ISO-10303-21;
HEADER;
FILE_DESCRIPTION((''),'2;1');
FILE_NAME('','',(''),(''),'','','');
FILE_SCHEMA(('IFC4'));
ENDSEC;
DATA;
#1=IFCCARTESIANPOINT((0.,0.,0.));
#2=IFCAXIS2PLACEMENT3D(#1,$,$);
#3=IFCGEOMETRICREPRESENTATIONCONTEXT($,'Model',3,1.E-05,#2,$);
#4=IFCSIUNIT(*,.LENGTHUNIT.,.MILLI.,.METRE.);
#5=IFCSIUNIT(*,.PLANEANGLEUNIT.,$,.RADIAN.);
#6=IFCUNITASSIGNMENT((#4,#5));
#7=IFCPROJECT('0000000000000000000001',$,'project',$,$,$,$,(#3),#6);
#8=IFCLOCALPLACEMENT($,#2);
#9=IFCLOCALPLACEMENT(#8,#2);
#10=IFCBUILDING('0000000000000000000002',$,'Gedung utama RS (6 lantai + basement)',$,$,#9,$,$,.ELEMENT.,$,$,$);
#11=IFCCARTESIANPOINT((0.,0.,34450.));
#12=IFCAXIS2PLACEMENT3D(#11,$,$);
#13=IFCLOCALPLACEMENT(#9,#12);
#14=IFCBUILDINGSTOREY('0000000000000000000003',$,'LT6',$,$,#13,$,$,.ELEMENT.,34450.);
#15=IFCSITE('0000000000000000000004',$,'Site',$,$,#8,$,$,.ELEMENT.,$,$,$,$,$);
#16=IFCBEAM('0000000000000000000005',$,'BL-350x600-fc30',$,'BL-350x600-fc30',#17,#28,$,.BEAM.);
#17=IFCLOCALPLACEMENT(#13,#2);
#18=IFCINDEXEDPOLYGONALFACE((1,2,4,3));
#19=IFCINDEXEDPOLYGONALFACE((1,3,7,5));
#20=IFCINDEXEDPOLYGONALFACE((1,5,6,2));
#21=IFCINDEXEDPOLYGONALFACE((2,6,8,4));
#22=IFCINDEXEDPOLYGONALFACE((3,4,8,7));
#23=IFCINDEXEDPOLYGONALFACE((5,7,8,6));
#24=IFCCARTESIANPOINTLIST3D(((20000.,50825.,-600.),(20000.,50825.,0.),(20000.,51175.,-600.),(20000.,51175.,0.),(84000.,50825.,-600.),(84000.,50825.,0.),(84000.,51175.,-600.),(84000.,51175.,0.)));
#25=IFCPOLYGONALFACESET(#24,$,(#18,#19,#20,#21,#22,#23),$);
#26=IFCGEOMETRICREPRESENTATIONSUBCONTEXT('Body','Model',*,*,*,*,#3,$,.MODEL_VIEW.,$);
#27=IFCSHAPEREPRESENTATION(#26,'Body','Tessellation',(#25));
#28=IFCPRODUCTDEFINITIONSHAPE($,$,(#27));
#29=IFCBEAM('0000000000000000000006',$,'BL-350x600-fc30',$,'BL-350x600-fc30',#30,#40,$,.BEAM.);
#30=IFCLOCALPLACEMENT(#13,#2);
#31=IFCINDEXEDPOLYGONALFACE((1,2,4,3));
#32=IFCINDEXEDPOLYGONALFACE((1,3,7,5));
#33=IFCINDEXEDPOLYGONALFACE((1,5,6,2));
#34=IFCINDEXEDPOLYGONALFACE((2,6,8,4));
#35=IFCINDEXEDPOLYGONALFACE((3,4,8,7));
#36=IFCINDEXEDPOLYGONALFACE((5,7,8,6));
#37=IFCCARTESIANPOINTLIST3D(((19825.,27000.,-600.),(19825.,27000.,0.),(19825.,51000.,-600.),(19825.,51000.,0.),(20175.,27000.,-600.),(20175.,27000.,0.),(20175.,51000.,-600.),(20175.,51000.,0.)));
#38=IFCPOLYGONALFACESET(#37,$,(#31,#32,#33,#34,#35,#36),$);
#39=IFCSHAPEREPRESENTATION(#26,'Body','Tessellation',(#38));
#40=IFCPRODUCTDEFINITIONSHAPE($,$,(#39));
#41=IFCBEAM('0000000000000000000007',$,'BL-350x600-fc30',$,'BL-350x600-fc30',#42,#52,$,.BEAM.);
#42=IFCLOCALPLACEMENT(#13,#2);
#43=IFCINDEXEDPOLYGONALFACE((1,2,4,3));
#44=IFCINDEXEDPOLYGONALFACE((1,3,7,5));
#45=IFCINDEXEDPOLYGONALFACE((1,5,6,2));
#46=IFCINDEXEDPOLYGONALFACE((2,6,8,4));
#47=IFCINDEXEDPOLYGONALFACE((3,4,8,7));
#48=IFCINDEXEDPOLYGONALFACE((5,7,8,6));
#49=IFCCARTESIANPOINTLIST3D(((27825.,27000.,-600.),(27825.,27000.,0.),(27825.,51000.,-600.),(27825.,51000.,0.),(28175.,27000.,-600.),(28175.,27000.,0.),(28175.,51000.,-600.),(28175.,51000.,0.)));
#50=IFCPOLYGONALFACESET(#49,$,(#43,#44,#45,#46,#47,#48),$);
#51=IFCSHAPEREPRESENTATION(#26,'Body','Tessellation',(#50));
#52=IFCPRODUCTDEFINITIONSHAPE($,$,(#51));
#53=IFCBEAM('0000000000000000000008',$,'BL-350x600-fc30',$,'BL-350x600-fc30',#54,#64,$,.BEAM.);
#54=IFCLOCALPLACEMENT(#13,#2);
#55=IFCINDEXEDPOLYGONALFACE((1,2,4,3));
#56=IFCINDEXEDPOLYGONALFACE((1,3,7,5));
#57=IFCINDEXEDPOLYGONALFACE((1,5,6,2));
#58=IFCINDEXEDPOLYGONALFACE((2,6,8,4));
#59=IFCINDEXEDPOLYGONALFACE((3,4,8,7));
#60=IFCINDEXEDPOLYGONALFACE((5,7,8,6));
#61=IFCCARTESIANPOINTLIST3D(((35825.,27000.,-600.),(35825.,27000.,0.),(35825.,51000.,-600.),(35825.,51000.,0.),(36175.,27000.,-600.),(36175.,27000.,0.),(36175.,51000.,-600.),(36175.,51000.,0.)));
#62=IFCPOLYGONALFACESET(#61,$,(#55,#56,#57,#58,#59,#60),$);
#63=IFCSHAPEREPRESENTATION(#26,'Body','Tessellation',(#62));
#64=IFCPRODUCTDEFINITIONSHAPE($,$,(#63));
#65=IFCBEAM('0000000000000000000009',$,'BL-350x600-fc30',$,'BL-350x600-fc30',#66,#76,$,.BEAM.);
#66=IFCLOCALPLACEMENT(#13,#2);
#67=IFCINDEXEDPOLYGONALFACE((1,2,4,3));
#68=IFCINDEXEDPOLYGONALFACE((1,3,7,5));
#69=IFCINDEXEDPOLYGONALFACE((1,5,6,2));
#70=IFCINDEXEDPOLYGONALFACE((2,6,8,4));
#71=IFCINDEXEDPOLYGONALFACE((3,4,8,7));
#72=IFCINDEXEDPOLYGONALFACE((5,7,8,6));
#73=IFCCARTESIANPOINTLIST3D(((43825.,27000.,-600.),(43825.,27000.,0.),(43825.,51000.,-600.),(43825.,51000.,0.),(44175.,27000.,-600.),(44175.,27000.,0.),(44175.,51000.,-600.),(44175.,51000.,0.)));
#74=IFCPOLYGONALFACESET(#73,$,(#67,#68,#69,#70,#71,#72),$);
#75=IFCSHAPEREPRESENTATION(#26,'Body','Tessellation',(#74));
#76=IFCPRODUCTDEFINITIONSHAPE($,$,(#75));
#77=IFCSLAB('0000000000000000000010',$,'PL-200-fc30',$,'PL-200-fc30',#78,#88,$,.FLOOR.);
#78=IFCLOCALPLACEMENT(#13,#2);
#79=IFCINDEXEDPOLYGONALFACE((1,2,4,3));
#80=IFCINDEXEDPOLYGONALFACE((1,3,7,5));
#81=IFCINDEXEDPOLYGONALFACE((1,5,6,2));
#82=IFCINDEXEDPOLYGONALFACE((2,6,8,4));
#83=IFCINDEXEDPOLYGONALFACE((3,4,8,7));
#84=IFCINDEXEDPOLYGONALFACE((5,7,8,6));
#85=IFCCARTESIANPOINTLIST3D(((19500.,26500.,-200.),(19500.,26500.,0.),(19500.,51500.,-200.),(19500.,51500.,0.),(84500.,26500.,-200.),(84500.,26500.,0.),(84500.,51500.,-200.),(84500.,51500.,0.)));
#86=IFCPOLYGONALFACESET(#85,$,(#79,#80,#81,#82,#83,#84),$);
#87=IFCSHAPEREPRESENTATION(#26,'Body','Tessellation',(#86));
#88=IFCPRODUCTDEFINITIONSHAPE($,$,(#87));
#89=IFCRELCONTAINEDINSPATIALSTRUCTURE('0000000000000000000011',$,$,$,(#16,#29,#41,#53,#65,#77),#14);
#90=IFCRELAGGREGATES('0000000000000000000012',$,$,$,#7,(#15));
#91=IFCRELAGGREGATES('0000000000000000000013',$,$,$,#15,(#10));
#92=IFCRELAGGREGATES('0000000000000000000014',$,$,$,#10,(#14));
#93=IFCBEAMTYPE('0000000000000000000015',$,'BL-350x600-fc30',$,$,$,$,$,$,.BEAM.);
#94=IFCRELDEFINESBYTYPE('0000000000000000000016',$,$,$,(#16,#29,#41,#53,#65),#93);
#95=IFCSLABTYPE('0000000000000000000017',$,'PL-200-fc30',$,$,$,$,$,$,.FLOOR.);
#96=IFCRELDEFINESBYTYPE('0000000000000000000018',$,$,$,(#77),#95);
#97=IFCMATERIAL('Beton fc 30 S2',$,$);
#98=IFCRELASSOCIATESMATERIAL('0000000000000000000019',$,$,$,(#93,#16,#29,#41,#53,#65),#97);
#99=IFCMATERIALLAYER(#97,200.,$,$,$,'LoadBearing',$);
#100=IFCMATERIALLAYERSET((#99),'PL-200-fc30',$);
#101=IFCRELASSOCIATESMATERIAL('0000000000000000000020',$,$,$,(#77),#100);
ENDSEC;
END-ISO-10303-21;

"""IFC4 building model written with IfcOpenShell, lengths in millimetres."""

from ifc_helpers import new_model, si_unit, frame, origin, origin_2d, place, context, subcontext, project, spatial, polyline, rectangle, outline, extrude, material, layer, layer_set, layer_usage, material_profile, profile_set, profile_usage, type_object, element, save


model = new_model("IFC4")

# Units and contexts
model_context = context("Model", 3, precision=1e-05, world=origin())
body_context = subcontext(model_context, "Body", "Model", "MODEL_VIEW")
ifc_project = project(units=[si_unit("LENGTHUNIT", "METRE", prefix="MILLI"), si_unit("PLANEANGLEUNIT", "RADIAN")], contexts=[model_context])

# Site, building, storey
site_placement = place(None, origin())
site = spatial("IfcSite", under=ifc_project, at=site_placement, Name="Site", CompositionType="ELEMENT")
building_placement = place(site_placement, origin())
building = spatial("IfcBuilding", under=site, at=building_placement, Name="Gedung utama RS (6 lantai + basement)", CompositionType="ELEMENT")
storey_placement = place(building_placement, frame((0.0, 0.0, 34450.0)))
storey = spatial("IfcBuildingStorey", under=building, at=storey_placement, Name="LT6", CompositionType="ELEMENT", Elevation=34450.0)

# Beams
ifc_material = material(Name="Beton fc 30 S2")
ifc_material_profile_1 = material_profile(ifc_material, rectangle(XDim=350.0, YDim=600.0, at=origin_2d()), Name="BL-350x600-fc30")
ifc_profile_set_1 = profile_set([ifc_material_profile_1], Name="BL-350x600-fc30")
ifc_profile_usage_1 = profile_usage(ifc_profile_set_1, cardinal=8)
beam_type = type_object("IfcBeamType", Name="BL-350x600-fc30", PredefinedType="BEAM", material=ifc_profile_set_1)
for number, where, name in (
    (1, (20000.0, 51000.0, -300.0), "BL-350x600-fc30"),
):
    element("IfcBeam", number, at=place(storey_placement, frame(where)), inside=storey, type_object=beam_type, material=ifc_profile_usage_1, Name=name, ObjectType="BL-350x600-fc30", PredefinedType="BEAM", context=body_context, shape_type="SweptSolid", body=[
        extrude(rectangle(XDim=350.0, YDim=600.0, at=origin_2d()), frame((0.0, 0.0, 0.0), z_axis=(1.0, 0.0, 0.0), x_axis=(0.0, 1.0, 0.0)), (0.0, 0.0, 1.0), 64000.0),
    ])
for number, where, name in (
    (2, (20000.0, 27000.0, -300.0), "BL-350x600-fc30"),
    (3, (28000.0, 27000.0, -300.0), "BL-350x600-fc30"),
    (4, (36000.0, 27000.0, -300.0), "BL-350x600-fc30"),
    (5, (44000.0, 27000.0, -300.0), "BL-350x600-fc30"),
):
    element("IfcBeam", number, at=place(storey_placement, frame(where)), inside=storey, type_object=beam_type, material=ifc_profile_usage_1, Name=name, ObjectType="BL-350x600-fc30", PredefinedType="BEAM", context=body_context, shape_type="SweptSolid", body=[
        extrude(rectangle(XDim=350.0, YDim=600.0, at=origin_2d()), frame((0.0, 0.0, 0.0), z_axis=(0.0, 1.0, 0.0), x_axis=(-1.0, 0.0, 0.0)), (0.0, 0.0, 1.0), 24000.0),
    ])

# Slab
ifc_layer = layer(ifc_material, 200.0, Category="LoadBearing")
ifc_layer_set = layer_set([ifc_layer], Name="PL-200-fc30")
ifc_layer_usage = layer_usage(ifc_layer_set, "AXIS3", "NEGATIVE", 0.0)
slab_type = type_object("IfcSlabType", Name="PL-200-fc30", PredefinedType="FLOOR")
slab_placement = place(storey_placement, origin())
element("IfcSlab", 6, at=slab_placement, inside=storey, type_object=slab_type, material=ifc_layer_usage, Name="PL-200-fc30", ObjectType="PL-200-fc30", PredefinedType="FLOOR", context=body_context, shape_type="SweptSolid", body=[
    extrude(outline(polyline([(19500.0, 26500.0), (84500.0, 26500.0), (84500.0, 51500.0), (19500.0, 51500.0), (19500.0, 26500.0)])), frame((0.0, 0.0, -200.0)), (0.0, 0.0, 1.0), 200.0),
])

save(model, "model.ifc")
